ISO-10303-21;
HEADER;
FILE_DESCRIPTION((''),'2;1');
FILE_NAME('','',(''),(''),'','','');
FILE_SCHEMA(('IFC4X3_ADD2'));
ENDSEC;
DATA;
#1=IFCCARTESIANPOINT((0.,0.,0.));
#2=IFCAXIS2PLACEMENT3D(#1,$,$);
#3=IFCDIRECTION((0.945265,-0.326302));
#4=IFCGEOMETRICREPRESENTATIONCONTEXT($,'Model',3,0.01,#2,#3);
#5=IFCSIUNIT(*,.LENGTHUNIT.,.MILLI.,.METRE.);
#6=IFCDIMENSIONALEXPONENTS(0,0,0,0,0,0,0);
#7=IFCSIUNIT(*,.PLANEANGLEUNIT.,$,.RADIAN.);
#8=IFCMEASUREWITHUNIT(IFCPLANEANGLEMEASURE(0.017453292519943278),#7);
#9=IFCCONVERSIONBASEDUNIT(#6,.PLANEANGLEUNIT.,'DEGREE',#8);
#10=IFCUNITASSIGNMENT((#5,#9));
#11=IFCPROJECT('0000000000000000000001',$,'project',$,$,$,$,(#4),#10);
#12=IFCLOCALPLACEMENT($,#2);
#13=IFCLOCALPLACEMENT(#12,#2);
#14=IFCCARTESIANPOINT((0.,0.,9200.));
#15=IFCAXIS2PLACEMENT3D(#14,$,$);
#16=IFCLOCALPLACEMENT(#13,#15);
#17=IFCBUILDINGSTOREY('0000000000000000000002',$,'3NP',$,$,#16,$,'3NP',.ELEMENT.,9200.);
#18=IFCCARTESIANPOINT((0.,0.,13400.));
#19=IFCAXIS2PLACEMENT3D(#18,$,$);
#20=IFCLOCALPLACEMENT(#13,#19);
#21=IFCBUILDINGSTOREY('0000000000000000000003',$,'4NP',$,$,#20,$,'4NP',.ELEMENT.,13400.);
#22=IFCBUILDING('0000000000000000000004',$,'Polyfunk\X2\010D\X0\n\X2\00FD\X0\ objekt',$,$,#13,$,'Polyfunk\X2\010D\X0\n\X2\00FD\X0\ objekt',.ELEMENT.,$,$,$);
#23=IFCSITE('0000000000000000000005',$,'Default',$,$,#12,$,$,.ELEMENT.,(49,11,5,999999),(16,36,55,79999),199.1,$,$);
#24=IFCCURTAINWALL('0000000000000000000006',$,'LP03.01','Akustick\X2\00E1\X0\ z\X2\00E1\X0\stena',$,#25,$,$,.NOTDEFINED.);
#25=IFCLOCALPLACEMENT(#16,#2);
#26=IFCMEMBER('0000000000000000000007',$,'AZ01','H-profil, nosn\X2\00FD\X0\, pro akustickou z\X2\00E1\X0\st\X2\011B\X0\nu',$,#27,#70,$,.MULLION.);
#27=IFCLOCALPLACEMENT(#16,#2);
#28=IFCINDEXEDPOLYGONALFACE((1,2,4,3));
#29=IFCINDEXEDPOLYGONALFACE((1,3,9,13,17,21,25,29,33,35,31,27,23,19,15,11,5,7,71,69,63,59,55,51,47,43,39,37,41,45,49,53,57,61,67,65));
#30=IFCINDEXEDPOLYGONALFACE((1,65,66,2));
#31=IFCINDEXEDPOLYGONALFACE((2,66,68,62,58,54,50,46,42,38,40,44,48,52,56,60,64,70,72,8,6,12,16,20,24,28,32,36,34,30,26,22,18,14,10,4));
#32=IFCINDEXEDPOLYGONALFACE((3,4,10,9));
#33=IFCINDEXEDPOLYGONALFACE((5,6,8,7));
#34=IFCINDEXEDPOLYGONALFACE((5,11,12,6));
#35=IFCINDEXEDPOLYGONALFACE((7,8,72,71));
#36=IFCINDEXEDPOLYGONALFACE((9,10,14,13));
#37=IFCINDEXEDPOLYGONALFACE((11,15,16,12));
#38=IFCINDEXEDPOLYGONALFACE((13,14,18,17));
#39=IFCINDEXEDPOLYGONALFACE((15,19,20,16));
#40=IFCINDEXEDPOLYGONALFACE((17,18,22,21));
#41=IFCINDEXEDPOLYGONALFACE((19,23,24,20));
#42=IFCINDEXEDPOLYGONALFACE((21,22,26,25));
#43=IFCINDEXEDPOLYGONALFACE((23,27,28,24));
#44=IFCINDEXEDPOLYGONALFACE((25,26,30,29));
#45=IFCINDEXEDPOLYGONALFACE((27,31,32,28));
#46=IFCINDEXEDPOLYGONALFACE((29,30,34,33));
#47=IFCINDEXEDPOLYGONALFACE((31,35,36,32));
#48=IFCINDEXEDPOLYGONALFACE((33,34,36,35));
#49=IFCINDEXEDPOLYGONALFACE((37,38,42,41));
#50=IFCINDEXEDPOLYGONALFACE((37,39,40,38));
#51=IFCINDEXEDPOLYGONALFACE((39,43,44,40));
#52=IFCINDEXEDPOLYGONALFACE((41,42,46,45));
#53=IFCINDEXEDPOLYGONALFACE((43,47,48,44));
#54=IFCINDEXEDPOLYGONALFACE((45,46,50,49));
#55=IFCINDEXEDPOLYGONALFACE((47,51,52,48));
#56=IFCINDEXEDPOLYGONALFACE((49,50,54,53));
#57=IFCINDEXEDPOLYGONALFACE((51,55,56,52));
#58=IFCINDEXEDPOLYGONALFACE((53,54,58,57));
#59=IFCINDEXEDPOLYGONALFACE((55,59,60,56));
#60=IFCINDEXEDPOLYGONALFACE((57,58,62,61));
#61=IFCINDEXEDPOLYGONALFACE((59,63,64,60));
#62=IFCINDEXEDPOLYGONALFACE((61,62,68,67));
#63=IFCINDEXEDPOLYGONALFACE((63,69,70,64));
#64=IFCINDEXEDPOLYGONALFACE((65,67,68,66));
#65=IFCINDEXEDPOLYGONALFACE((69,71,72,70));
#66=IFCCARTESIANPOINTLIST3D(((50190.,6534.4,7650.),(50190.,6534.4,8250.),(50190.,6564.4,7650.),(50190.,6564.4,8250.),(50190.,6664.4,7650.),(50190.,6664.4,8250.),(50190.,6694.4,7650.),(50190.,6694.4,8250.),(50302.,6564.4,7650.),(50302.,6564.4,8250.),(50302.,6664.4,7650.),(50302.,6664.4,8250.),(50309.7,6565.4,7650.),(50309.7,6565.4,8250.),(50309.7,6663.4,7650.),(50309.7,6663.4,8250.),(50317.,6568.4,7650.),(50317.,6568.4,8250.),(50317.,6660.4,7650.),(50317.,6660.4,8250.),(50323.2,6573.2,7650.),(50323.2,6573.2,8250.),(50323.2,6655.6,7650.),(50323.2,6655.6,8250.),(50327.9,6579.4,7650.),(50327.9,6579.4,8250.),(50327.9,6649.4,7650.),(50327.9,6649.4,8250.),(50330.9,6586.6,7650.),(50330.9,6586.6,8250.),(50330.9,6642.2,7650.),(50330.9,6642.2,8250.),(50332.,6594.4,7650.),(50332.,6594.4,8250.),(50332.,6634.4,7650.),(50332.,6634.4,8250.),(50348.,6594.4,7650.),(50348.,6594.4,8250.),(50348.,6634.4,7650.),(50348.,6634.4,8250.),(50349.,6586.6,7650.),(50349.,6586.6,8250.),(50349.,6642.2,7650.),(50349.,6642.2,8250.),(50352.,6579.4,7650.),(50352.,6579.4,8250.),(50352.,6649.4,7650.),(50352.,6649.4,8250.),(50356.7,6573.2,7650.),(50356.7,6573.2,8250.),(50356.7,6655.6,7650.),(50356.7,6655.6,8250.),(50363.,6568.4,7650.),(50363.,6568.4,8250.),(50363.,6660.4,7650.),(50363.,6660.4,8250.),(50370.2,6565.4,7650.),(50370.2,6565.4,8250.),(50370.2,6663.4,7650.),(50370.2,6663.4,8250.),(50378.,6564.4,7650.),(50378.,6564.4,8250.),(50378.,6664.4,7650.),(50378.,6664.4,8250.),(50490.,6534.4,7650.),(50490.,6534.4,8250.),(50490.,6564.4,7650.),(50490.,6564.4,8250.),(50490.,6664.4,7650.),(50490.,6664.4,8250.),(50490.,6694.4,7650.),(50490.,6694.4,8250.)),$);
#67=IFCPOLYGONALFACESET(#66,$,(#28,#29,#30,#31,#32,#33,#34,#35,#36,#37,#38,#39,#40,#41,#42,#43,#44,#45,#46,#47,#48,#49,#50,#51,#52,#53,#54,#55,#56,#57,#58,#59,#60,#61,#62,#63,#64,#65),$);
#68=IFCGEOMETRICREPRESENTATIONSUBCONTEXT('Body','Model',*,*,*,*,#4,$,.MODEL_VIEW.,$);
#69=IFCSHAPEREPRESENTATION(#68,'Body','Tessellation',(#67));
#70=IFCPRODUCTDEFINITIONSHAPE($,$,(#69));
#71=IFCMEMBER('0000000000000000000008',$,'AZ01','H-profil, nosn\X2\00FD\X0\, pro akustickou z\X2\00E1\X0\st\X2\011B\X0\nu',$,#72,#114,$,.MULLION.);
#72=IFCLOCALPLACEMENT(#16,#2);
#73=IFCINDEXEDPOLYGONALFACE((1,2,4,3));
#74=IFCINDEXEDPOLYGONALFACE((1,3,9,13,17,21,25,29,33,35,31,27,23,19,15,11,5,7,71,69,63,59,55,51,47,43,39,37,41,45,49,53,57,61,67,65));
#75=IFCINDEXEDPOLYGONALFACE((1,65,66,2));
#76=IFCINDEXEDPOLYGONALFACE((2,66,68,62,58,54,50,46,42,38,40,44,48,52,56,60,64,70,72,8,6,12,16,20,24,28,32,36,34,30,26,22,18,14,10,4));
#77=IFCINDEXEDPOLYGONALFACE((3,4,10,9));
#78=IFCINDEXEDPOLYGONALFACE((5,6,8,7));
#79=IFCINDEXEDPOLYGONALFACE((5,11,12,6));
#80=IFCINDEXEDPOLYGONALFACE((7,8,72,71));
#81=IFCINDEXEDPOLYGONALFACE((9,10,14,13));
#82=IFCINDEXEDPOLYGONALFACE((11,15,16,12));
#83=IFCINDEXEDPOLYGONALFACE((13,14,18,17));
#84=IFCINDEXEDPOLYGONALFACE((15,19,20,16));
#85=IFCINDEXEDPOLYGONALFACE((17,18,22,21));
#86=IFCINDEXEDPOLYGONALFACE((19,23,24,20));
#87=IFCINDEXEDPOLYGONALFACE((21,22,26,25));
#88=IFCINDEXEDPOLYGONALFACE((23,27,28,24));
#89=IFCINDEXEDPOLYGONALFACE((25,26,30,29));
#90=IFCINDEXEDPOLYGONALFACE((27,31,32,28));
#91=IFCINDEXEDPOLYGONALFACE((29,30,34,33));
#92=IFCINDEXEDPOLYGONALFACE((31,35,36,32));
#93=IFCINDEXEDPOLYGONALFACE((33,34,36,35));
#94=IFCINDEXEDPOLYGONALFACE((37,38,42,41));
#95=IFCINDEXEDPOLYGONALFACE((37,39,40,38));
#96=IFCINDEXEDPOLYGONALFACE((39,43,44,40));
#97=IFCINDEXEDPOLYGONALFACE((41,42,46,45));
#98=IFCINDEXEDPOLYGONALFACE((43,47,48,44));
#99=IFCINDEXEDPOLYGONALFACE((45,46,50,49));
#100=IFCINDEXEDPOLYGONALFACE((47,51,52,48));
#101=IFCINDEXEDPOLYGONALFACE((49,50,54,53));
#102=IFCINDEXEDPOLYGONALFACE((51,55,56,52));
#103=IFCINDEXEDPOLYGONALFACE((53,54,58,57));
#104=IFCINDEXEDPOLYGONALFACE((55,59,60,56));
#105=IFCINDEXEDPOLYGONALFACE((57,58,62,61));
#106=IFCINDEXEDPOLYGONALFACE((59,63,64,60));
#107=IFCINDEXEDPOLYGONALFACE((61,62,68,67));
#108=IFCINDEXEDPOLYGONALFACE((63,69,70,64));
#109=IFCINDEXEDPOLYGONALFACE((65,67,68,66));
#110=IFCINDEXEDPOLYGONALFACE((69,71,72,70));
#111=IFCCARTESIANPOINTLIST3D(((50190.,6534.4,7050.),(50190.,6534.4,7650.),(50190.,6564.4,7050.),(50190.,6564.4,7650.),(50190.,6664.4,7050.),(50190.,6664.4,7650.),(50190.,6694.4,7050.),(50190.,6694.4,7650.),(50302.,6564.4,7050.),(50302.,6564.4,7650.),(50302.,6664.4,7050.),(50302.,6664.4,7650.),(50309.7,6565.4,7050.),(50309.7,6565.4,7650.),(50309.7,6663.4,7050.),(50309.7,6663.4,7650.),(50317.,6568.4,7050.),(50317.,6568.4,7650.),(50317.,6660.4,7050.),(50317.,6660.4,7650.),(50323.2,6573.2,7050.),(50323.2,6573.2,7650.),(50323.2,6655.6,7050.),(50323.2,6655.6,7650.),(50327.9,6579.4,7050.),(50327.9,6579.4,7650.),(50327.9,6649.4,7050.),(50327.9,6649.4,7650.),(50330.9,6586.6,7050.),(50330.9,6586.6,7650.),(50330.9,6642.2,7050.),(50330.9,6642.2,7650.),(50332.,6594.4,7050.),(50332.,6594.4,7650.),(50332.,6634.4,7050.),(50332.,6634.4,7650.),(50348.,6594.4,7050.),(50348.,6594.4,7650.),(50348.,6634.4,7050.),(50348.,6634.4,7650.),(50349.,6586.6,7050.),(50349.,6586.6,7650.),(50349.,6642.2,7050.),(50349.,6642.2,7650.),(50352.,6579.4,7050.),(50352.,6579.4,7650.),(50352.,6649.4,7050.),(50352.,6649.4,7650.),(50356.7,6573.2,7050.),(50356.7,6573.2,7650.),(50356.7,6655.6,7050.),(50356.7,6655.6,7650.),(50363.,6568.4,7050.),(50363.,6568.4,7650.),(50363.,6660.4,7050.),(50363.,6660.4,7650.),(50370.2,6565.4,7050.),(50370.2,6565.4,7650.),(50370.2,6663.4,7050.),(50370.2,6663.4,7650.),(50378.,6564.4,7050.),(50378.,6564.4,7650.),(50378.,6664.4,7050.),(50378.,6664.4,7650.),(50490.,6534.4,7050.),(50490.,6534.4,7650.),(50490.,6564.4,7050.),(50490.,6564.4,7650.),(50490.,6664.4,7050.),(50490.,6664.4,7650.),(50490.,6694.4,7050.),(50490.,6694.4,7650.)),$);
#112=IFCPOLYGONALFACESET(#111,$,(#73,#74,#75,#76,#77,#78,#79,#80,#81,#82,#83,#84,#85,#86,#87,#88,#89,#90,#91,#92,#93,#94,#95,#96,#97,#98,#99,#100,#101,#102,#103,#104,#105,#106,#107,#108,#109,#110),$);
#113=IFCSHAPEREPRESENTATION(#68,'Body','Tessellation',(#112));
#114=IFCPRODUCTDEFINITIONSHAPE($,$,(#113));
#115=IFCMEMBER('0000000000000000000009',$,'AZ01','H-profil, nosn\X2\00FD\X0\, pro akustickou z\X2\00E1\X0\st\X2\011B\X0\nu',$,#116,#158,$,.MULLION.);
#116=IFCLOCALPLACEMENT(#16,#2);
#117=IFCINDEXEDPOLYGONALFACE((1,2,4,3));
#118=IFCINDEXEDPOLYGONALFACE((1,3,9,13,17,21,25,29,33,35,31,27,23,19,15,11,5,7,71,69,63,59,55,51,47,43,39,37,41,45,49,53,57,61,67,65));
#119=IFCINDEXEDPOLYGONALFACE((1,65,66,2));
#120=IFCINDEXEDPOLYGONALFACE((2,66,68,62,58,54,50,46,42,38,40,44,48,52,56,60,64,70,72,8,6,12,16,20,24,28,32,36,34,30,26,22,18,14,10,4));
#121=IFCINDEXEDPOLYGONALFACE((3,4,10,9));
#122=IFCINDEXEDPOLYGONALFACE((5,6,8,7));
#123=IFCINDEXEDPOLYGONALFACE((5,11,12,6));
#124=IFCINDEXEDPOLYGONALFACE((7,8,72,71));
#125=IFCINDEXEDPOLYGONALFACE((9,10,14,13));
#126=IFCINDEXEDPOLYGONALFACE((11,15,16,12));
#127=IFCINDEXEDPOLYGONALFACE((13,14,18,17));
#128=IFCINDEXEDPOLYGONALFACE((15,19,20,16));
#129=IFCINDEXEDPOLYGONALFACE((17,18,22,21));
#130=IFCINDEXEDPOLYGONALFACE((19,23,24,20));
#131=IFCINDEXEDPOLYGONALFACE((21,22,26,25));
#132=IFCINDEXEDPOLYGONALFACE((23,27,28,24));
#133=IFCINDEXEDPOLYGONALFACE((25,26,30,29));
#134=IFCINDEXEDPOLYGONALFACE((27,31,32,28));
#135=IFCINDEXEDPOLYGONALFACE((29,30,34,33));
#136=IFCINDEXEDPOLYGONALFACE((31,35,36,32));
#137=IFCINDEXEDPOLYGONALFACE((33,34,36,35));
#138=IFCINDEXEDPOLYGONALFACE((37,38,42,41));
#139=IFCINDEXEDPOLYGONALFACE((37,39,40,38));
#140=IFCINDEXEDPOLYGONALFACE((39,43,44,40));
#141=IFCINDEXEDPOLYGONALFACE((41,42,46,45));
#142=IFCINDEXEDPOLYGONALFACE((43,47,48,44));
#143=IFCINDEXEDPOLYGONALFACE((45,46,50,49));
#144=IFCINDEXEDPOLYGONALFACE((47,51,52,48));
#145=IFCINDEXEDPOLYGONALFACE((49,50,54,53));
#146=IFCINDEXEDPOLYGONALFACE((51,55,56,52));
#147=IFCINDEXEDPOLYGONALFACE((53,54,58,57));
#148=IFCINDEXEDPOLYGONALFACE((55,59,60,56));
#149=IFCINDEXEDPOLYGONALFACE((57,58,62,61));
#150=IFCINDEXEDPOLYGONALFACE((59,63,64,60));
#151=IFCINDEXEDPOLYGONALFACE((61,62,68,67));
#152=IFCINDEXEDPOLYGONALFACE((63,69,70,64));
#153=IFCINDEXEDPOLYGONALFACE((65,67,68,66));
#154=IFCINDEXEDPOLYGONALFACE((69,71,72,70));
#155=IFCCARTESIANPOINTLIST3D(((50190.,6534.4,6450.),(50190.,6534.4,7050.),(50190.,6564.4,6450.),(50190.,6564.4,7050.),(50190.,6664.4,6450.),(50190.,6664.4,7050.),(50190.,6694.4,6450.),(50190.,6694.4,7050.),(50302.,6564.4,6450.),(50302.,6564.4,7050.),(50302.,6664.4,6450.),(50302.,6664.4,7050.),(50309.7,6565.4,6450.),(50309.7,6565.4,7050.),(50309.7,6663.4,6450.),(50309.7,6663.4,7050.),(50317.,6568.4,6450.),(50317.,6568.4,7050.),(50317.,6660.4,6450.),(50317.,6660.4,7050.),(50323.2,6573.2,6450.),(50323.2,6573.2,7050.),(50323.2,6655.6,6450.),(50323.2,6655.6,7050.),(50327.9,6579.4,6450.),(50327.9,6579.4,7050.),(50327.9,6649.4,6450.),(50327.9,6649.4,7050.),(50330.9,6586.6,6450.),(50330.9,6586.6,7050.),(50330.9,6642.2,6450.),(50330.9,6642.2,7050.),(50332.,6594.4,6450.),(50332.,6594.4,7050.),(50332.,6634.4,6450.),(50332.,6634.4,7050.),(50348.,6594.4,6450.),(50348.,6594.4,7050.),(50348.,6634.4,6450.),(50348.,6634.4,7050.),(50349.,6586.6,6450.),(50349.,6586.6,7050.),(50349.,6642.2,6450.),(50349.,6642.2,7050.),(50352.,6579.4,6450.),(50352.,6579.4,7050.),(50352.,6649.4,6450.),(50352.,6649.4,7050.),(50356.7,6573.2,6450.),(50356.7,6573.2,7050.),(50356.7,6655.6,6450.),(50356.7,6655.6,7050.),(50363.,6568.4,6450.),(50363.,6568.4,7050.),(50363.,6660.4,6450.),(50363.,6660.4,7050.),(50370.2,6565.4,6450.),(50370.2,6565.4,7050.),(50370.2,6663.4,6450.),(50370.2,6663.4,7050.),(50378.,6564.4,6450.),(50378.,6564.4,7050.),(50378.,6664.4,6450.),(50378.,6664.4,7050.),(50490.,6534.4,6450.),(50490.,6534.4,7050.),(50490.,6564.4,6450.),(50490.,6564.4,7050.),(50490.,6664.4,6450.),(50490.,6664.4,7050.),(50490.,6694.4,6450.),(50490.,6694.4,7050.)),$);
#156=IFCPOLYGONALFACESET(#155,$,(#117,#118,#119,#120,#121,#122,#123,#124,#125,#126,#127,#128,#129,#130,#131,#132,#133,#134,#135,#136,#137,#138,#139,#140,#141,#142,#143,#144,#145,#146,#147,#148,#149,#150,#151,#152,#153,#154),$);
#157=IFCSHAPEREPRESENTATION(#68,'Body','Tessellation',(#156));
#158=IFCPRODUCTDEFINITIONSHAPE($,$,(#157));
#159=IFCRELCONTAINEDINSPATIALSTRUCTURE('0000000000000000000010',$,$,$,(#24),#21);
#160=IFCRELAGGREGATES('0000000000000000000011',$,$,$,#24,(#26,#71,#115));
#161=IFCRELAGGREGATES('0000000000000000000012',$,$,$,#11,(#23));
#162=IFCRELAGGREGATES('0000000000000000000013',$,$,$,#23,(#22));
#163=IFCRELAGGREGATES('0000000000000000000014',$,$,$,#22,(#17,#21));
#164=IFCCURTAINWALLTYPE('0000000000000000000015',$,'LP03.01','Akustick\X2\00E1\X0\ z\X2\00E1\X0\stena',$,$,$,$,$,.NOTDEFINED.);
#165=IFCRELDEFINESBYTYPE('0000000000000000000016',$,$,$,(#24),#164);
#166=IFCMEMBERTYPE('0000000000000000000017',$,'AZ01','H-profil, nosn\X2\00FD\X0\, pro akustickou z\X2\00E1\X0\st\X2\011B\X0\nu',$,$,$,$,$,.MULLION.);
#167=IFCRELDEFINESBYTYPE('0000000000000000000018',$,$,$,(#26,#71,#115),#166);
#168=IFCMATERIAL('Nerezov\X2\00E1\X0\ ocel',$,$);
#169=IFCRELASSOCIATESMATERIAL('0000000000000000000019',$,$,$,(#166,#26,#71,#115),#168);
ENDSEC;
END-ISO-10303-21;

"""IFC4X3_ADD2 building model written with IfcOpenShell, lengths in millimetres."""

from ifc_helpers import new_model, entity, si_unit, converted_unit, direction, frame, frame_2d, origin, place, context, subcontext, project, spatial, polyline, circle_curve, parameter, trimmed, segment, composite_curve, outline, extrude, source, transform, mapped, material, material_profile, profile_set, profile_usage, type_object, element, aggregate, save


model = new_model("IFC4X3_ADD2")

# Units and contexts
model_context = context("Model", 3, precision=0.01, world=origin(), true_north=direction((0.945265, -0.326302)))
body_context = subcontext(model_context, "Body", "Model", "MODEL_VIEW")
ifc_project = project(units=[si_unit("LENGTHUNIT", "METRE", prefix="MILLI"), converted_unit("PLANEANGLEUNIT", "DEGREE", entity("IfcPlaneAngleMeasure", 0.017453292519943278), si_unit("PLANEANGLEUNIT", "RADIAN"), dimensions=[0, 0, 0, 0, 0, 0, 0])], contexts=[model_context])

# Site, building, storey
site_placement = place(None, origin())
site = spatial("IfcSite", under=ifc_project, at=site_placement, Name="Default", CompositionType="ELEMENT", RefLatitude=(49, 11, 5, 999999), RefLongitude=(16, 36, 55, 79999), RefElevation=199.1)
building_placement = place(site_placement, origin())
building = spatial("IfcBuilding", under=site, at=building_placement, Name="Polyfunkčný objekt", LongName="Polyfunkčný objekt", CompositionType="ELEMENT")
storey_1_placement = place(building_placement, frame((0.0, 0.0, 9200.0)))
storey_1 = spatial("IfcBuildingStorey", under=building, at=storey_1_placement, Name="3NP", LongName="3NP", CompositionType="ELEMENT", Elevation=9200.0)

# Shared definitions
storey_2_placement = place(building_placement, frame((0.0, 0.0, 13400.0)))
storey_2 = spatial("IfcBuildingStorey", under=building, at=storey_2_placement, Name="4NP", LongName="4NP", CompositionType="ELEMENT", Elevation=13400.0)

# Curtain wall, members
curtain_wall_type_1 = type_object("IfcCurtainWallType", Name="LP03.01", Description="Akustická zástena", PredefinedType="NOTDEFINED")
curtain_wall_1_placement = place(storey_2_placement, frame((0.0, 0.0, -13400.0)))
curtain_wall_1 = element("IfcCurtainWall", 1, at=curtain_wall_1_placement, inside=storey_2, type_object=curtain_wall_type_1, Name="LP03.01", Description="Akustická zástena", PredefinedType="NOTDEFINED")
ifc_material_1 = material(Name="Nerezová ocel")
ifc_material_profile_1 = material_profile(ifc_material_1, outline(composite_curve([segment(polyline([(50.0, -150.0), (80.0, -150.0)]), True, "CONTINUOUS"), segment(polyline([(80.0, -150.0), (80.0, 150.0)]), True, "CONTINUOUS"), segment(polyline([(80.0, 150.0), (50.0, 150.0)]), True, "CONTINUOUS"), segment(polyline([(50.0, 150.0), (50.0, 38.0)]), True, "CONTINUOUS"), segment(trimmed(circle_curve(frame_2d((20.0, 38.0), x_axis=(0.0, 1.0)), 30.0), [parameter(180.0)], [parameter(270.0)], True, "PARAMETER"), False, "CONTINUOUS"), segment(polyline([(20.0, 8.0), (-20.0, 8.0)]), True, "CONTINUOUS"), segment(trimmed(circle_curve(frame_2d((-20.0, 38.0), x_axis=(0.0, 1.0)), 30.0), [parameter(90.0)], [parameter(180.0)], True, "PARAMETER"), False, "CONTINUOUS"), segment(polyline([(-50.0, 38.0), (-50.0, 150.0)]), True, "CONTINUOUS"), segment(polyline([(-50.0, 150.0), (-80.0, 150.0)]), True, "CONTINUOUS"), segment(polyline([(-80.0, 150.0), (-80.0, -150.0)]), True, "CONTINUOUS"), segment(polyline([(-80.0, -150.0), (-50.0, -150.0)]), True, "CONTINUOUS"), segment(polyline([(-50.0, -150.0), (-50.0, -38.0)]), True, "CONTINUOUS"), segment(trimmed(circle_curve(frame_2d((-20.0, -38.0), x_axis=(0.0, 1.0)), 30.0), [parameter(0.0)], [parameter(90.0)], True, "PARAMETER"), False, "CONTINUOUS"), segment(polyline([(-20.0, -8.0), (20.0, -8.0)]), True, "CONTINUOUS"), segment(trimmed(circle_curve(frame_2d((20.0, -38.0), x_axis=(0.0, 1.0)), 30.0), [parameter(270.0)], [parameter(0.0)], True, "PARAMETER"), False, "CONTINUOUS"), segment(polyline([(50.0, -38.0), (50.0, -150.0)]), True, "CONTINUOUS")], self_intersect=False)), Name="Profil zástena")
ifc_profile_set_1 = profile_set([ifc_material_profile_1], Name="Profil zástena")
ifc_profile_usage_1 = profile_usage(ifc_profile_set_1)
member_type_1 = type_object("IfcMemberType", Name="AZ01", Description="H-profil, nosný, pro akustickou zástěnu", PredefinedType="MULLION", material=ifc_profile_set_1)
shared_shape_1 = source(origin(), body_context, "Body", "SweptSolid", [
    extrude(outline(composite_curve([segment(polyline([(-150.0, -50.0), (-150.0, -80.0)]), True, "CONTINUOUS"), segment(polyline([(-150.0, -80.0), (150.0, -80.0)]), True, "CONTINUOUS"), segment(polyline([(150.0, -80.0), (150.0, -50.0)]), True, "CONTINUOUS"), segment(polyline([(150.0, -50.0), (38.0, -50.0)]), True, "CONTINUOUS"), segment(trimmed(circle_curve(frame_2d((38.0, -20.0), x_axis=(1.0, 0.0)), 30.0), [parameter(180.0)], [parameter(270.0)], True, "PARAMETER"), False, "CONTINUOUS"), segment(polyline([(8.0, -20.0), (8.0, 20.0)]), True, "CONTINUOUS"), segment(trimmed(circle_curve(frame_2d((38.0, 20.0), x_axis=(1.0, 0.0)), 30.0), [parameter(90.0)], [parameter(180.0)], True, "PARAMETER"), False, "CONTINUOUS"), segment(polyline([(38.0, 50.0), (150.0, 50.0)]), True, "CONTINUOUS"), segment(polyline([(150.0, 50.0), (150.0, 80.0)]), True, "CONTINUOUS"), segment(polyline([(150.0, 80.0), (-150.0, 80.0)]), True, "CONTINUOUS"), segment(polyline([(-150.0, 80.0), (-150.0, 50.0)]), True, "CONTINUOUS"), segment(polyline([(-150.0, 50.0), (-38.0, 50.0)]), True, "CONTINUOUS"), segment(trimmed(circle_curve(frame_2d((-38.0, 20.0), x_axis=(1.0, 0.0)), 30.0), [parameter(0.0)], [parameter(90.0)], True, "PARAMETER"), False, "CONTINUOUS"), segment(polyline([(-8.0, 20.0), (-8.0, -20.0)]), True, "CONTINUOUS"), segment(trimmed(circle_curve(frame_2d((-38.0, -20.0), x_axis=(1.0, 0.0)), 30.0), [parameter(270.0)], [parameter(0.0)], True, "PARAMETER"), False, "CONTINUOUS"), segment(polyline([(-38.0, -50.0), (-150.0, -50.0)]), True, "CONTINUOUS")], self_intersect=False)), frame((-150.0, 0.0, -600.0), z_axis=(0.0, 0.0, -1.0), x_axis=(-1.0, 0.0, 0.0)), (0.0, 0.0, -1.0), 600.0),
])
member_1_placement = place(curtain_wall_1_placement, frame((50190.0, 6614.4, 17450.0), z_axis=(0.0, 0.0, 1.0), x_axis=(-1.0, 0.0, 0.0)))
member_1 = element("IfcMember", 2, at=member_1_placement, type_object=member_type_1, material=ifc_profile_usage_1, Name="AZ01", Description="H-profil, nosný, pro akustickou zástěnu", PredefinedType="MULLION", context=body_context, shape_type="MappedRepresentation", body=[
    mapped(shared_shape_1, transform((0.0, 0.0, 0.0), scale=1.0)),
])
member_2_placement = place(curtain_wall_1_placement, frame((50190.0, 6614.4, 16850.0), z_axis=(0.0, 0.0, 1.0), x_axis=(-1.0, 0.0, 0.0)))
member_2 = element("IfcMember", 3, at=member_2_placement, type_object=member_type_1, material=ifc_profile_usage_1, Name="AZ01", Description="H-profil, nosný, pro akustickou zástěnu", PredefinedType="MULLION", context=body_context, shape_type="MappedRepresentation", body=[
    mapped(shared_shape_1, transform((0.0, 0.0, 0.0), scale=1.0)),
])
member_3_placement = place(curtain_wall_1_placement, frame((50190.0, 6614.4, 16250.0), z_axis=(0.0, 0.0, 1.0), x_axis=(-1.0, 0.0, 0.0)))
member_3 = element("IfcMember", 4, at=member_3_placement, type_object=member_type_1, material=ifc_profile_usage_1, Name="AZ01", Description="H-profil, nosný, pro akustickou zástěnu", PredefinedType="MULLION", context=body_context, shape_type="MappedRepresentation", body=[
    mapped(shared_shape_1, transform((0.0, 0.0, 0.0), scale=1.0)),
])

aggregate(curtain_wall_1, [member_1, member_2, member_3])

save(model, "model.ifc")
